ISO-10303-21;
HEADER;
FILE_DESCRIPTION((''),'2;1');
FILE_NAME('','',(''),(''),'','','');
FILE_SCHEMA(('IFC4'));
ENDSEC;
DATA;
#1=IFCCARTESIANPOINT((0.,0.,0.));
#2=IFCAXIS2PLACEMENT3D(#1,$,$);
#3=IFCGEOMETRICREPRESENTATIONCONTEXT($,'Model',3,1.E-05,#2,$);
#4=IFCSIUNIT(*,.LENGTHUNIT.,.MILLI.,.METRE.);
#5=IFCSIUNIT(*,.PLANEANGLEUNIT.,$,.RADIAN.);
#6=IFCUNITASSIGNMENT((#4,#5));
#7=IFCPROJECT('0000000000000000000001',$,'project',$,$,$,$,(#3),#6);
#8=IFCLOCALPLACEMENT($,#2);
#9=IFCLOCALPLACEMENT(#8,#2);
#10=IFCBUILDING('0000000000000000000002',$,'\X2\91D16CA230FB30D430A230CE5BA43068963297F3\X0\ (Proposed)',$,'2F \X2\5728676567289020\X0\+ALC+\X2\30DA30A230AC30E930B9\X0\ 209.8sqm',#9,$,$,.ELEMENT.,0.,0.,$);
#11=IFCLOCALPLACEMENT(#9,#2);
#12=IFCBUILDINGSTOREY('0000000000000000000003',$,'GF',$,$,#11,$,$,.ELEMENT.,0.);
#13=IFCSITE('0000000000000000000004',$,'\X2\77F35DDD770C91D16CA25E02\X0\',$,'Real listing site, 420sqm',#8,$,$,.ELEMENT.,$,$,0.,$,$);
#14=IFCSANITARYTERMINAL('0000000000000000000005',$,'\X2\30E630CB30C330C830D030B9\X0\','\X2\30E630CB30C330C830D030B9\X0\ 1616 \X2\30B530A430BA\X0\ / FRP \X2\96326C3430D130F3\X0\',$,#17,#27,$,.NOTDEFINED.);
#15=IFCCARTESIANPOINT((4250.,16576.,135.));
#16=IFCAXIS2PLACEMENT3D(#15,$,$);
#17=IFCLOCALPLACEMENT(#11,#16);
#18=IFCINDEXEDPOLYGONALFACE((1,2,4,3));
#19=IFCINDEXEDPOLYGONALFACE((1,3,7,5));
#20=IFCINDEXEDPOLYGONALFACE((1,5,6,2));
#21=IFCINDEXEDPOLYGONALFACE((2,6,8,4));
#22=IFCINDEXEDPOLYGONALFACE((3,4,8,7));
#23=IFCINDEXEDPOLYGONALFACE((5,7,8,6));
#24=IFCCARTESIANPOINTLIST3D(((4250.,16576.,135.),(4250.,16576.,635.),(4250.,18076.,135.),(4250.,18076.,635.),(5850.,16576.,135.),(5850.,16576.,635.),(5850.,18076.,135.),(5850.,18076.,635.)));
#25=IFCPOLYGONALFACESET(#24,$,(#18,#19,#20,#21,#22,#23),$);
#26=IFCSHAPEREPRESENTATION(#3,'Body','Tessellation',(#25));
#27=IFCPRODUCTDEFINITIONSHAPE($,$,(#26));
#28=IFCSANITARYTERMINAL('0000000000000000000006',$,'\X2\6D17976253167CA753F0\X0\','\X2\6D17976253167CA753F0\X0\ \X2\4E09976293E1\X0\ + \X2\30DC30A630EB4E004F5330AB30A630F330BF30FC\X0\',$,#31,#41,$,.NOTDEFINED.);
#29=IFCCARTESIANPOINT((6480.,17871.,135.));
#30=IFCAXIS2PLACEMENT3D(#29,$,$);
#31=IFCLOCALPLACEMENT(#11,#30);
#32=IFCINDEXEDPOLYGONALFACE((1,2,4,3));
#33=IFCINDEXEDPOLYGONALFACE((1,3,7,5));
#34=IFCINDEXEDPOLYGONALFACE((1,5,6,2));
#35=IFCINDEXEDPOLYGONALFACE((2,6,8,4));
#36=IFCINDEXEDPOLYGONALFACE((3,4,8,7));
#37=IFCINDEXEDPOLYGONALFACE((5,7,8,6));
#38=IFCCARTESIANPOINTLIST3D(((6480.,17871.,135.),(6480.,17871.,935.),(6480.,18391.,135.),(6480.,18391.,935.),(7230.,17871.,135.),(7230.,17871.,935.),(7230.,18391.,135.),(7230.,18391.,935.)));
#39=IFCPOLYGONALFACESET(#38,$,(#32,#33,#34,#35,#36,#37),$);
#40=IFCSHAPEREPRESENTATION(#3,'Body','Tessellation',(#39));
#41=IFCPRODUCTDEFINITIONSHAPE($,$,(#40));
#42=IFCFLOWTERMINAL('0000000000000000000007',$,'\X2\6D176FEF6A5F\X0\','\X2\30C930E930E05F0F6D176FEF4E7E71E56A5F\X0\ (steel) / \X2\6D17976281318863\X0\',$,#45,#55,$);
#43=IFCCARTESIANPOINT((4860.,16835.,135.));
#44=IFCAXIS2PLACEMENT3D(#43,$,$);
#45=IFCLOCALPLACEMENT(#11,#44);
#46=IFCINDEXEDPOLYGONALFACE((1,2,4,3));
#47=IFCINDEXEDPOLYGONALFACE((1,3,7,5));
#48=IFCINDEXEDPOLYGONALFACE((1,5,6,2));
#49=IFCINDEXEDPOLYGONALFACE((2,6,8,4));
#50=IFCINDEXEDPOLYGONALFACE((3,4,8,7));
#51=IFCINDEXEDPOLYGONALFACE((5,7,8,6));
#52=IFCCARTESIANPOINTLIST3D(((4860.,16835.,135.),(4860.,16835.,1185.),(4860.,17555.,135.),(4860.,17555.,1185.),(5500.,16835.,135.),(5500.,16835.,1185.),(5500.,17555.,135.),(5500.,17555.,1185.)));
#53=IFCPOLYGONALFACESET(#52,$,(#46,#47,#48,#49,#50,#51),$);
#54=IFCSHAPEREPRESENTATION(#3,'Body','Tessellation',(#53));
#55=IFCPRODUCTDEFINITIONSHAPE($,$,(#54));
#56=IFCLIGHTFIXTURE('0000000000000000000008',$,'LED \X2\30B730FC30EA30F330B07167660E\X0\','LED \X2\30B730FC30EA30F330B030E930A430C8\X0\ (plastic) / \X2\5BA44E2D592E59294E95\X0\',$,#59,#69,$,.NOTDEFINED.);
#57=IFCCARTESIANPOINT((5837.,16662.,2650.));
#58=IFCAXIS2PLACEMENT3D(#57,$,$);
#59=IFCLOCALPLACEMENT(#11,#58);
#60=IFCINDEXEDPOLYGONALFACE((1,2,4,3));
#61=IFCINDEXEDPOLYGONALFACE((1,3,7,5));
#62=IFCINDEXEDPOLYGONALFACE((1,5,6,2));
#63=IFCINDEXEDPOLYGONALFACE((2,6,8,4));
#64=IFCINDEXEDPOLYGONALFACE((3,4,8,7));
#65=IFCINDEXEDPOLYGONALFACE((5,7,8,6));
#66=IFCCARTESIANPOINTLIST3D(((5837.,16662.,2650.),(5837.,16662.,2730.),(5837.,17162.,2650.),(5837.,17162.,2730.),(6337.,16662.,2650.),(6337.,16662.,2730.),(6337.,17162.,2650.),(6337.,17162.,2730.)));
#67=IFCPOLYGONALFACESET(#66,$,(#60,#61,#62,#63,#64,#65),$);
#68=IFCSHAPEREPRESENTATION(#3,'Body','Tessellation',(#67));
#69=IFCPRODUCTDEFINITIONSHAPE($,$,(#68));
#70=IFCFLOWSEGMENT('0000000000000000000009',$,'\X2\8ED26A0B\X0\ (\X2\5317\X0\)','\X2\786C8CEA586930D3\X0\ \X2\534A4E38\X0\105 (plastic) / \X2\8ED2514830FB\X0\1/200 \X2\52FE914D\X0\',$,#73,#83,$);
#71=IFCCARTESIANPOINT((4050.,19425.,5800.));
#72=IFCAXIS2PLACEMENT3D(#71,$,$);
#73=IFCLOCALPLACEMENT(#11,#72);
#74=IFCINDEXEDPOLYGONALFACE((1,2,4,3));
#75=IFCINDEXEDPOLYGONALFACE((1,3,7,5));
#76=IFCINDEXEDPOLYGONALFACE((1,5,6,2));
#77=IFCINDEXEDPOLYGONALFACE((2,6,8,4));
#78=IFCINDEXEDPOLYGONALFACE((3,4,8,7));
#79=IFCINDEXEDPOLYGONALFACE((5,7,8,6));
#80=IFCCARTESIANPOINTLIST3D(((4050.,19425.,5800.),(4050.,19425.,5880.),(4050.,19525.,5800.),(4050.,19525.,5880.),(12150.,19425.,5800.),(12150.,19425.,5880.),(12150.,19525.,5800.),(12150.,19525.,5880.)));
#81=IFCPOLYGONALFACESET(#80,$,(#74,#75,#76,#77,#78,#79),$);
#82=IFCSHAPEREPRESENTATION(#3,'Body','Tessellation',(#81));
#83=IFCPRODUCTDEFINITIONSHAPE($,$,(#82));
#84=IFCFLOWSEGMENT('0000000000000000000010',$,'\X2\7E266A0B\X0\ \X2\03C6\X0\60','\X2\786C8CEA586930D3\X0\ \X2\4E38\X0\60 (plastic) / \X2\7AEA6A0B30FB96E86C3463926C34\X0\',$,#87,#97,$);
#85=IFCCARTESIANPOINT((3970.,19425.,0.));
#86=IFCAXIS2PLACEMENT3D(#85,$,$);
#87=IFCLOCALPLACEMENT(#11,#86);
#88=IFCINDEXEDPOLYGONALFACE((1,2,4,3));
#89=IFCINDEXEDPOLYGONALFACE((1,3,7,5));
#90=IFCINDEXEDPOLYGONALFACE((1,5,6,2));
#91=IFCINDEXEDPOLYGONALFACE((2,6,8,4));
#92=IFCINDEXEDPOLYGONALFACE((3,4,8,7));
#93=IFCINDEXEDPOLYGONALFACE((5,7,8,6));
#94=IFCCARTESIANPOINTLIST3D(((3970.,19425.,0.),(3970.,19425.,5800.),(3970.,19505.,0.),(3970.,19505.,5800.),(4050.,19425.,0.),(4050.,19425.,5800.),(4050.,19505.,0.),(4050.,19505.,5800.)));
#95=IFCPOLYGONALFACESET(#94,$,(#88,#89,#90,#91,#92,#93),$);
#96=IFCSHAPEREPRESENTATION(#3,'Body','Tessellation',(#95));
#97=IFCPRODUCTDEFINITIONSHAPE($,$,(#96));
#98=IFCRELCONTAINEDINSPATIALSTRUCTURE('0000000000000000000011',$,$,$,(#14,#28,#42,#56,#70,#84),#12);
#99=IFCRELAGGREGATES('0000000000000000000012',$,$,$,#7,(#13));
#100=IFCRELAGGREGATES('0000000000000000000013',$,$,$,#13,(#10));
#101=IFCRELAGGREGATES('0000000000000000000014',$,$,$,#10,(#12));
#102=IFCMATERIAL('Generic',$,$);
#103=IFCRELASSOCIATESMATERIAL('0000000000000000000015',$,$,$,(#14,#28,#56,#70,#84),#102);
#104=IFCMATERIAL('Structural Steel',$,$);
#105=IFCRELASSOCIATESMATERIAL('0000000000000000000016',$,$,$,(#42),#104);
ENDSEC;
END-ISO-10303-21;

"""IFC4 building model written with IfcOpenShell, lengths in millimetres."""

from ifc_helpers import new_model, si_unit, frame, frame_2d, origin, place, context, project, spatial, rectangle, extrude, material, element, save


model = new_model("IFC4")

# Units and contexts
model_context = context("Model", 3, precision=1e-05, world=origin())
ifc_project = project(units=[si_unit("LENGTHUNIT", "METRE", prefix="MILLI"), si_unit("PLANEANGLEUNIT", "RADIAN")], contexts=[model_context])

# Site, building, storey
site_placement = place(None, origin())
site = spatial("IfcSite", under=ifc_project, at=site_placement, Name="石川県金沢市", ObjectType="Real listing site, 420sqm", CompositionType="ELEMENT", RefElevation=0.0)
building_placement = place(site_placement, origin())
building = spatial("IfcBuilding", under=site, at=building_placement, Name="金沢・ピアノ室と防音 (Proposed)", ObjectType="2F 在来木造+ALC+ペアガラス 209.8sqm", CompositionType="ELEMENT", ElevationOfRefHeight=0.0, ElevationOfTerrain=0.0)
storey_placement = place(building_placement, origin())
storey = spatial("IfcBuildingStorey", under=building, at=storey_placement, Name="GF", CompositionType="ELEMENT", Elevation=0.0)

# Sanitary terminals
ifc_material_1 = material(Name="Generic")
sanitary_terminal_1_placement = place(storey_placement, frame((4250.0, 16576.0, 135.0)))
element("IfcSanitaryTerminal", 1, at=sanitary_terminal_1_placement, inside=storey, material=ifc_material_1, Name="ユニットバス", Description="ユニットバス 1616 サイズ / FRP 防水パン", PredefinedType="NOTDEFINED", context=model_context, shape_type="SweptSolid", body=[
    extrude(rectangle(XDim=1600.0, YDim=1500.0, at=frame_2d((800.0, 750.0))), frame((4250.0, 16576.0, 135.0)), (0.0, 0.0, 1.0), 500.0),
])
sanitary_terminal_2_placement = place(storey_placement, frame((6480.0, 17871.0, 135.0)))
element("IfcSanitaryTerminal", 2, at=sanitary_terminal_2_placement, inside=storey, material=ifc_material_1, Name="洗面化粧台", Description="洗面化粧台 三面鏡 + ボウル一体カウンター", PredefinedType="NOTDEFINED", context=model_context, shape_type="SweptSolid", body=[
    extrude(rectangle(XDim=750.0, YDim=520.0, at=frame_2d((375.0, 260.0))), frame((6480.0, 17871.0, 135.0)), (0.0, 0.0, 1.0), 800.0),
])

# Flow terminal
ifc_material_2 = material(Name="Structural Steel")
flow_terminal_placement = place(storey_placement, frame((4860.0, 16835.0, 135.0)))
element("IfcFlowTerminal", 3, at=flow_terminal_placement, inside=storey, material=ifc_material_2, Name="洗濯機", Description="ドラム式洗濯乾燥機 (steel) / 洗面脱衣", context=model_context, shape_type="SweptSolid", body=[
    extrude(rectangle(XDim=640.0, YDim=720.0, at=frame_2d((320.0, 360.0))), frame((4860.0, 16835.0, 135.0)), (0.0, 0.0, 1.0), 1050.0),
])

# Light fixture
light_fixture_placement = place(storey_placement, frame((5837.0, 16662.0, 2650.0)))
element("IfcLightFixture", 4, at=light_fixture_placement, inside=storey, material=ifc_material_1, Name="LED シーリング照明", Description="LED シーリングライト (plastic) / 室中央天井", PredefinedType="NOTDEFINED", context=model_context, shape_type="SweptSolid", body=[
    extrude(rectangle(XDim=500.0, YDim=500.0, at=frame_2d((250.0, 250.0))), frame((5837.0, 16662.0, 2650.0)), (0.0, 0.0, 1.0), 80.0),
])

# Flow segments
flow_segment_1_placement = place(storey_placement, frame((4050.0, 19425.0, 5800.0)))
element("IfcFlowSegment", 5, at=flow_segment_1_placement, inside=storey, material=ifc_material_1, Name="軒樋 (北)", Description="硬質塩ビ 半丸105 (plastic) / 軒先・1/200 勾配", context=model_context, shape_type="SweptSolid", body=[
    extrude(rectangle(XDim=8100.0, YDim=100.0, at=frame_2d((4050.0, 50.0))), frame((4050.0, 19425.0, 5800.0)), (0.0, 0.0, 1.0), 80.0),
])
flow_segment_2_placement = place(storey_placement, frame((3970.0, 19425.0, 0.0)))
element("IfcFlowSegment", 6, at=flow_segment_2_placement, inside=storey, material=ifc_material_1, Name="縦樋 φ60", Description="硬質塩ビ 丸60 (plastic) / 竪樋・雨水排水", context=model_context, shape_type="SweptSolid", body=[
    extrude(rectangle(XDim=80.0, YDim=80.0, at=frame_2d((40.0, 40.0))), frame((3970.0, 19425.0, 0.0)), (0.0, 0.0, 1.0), 5800.0),
])

save(model, "model.ifc")
